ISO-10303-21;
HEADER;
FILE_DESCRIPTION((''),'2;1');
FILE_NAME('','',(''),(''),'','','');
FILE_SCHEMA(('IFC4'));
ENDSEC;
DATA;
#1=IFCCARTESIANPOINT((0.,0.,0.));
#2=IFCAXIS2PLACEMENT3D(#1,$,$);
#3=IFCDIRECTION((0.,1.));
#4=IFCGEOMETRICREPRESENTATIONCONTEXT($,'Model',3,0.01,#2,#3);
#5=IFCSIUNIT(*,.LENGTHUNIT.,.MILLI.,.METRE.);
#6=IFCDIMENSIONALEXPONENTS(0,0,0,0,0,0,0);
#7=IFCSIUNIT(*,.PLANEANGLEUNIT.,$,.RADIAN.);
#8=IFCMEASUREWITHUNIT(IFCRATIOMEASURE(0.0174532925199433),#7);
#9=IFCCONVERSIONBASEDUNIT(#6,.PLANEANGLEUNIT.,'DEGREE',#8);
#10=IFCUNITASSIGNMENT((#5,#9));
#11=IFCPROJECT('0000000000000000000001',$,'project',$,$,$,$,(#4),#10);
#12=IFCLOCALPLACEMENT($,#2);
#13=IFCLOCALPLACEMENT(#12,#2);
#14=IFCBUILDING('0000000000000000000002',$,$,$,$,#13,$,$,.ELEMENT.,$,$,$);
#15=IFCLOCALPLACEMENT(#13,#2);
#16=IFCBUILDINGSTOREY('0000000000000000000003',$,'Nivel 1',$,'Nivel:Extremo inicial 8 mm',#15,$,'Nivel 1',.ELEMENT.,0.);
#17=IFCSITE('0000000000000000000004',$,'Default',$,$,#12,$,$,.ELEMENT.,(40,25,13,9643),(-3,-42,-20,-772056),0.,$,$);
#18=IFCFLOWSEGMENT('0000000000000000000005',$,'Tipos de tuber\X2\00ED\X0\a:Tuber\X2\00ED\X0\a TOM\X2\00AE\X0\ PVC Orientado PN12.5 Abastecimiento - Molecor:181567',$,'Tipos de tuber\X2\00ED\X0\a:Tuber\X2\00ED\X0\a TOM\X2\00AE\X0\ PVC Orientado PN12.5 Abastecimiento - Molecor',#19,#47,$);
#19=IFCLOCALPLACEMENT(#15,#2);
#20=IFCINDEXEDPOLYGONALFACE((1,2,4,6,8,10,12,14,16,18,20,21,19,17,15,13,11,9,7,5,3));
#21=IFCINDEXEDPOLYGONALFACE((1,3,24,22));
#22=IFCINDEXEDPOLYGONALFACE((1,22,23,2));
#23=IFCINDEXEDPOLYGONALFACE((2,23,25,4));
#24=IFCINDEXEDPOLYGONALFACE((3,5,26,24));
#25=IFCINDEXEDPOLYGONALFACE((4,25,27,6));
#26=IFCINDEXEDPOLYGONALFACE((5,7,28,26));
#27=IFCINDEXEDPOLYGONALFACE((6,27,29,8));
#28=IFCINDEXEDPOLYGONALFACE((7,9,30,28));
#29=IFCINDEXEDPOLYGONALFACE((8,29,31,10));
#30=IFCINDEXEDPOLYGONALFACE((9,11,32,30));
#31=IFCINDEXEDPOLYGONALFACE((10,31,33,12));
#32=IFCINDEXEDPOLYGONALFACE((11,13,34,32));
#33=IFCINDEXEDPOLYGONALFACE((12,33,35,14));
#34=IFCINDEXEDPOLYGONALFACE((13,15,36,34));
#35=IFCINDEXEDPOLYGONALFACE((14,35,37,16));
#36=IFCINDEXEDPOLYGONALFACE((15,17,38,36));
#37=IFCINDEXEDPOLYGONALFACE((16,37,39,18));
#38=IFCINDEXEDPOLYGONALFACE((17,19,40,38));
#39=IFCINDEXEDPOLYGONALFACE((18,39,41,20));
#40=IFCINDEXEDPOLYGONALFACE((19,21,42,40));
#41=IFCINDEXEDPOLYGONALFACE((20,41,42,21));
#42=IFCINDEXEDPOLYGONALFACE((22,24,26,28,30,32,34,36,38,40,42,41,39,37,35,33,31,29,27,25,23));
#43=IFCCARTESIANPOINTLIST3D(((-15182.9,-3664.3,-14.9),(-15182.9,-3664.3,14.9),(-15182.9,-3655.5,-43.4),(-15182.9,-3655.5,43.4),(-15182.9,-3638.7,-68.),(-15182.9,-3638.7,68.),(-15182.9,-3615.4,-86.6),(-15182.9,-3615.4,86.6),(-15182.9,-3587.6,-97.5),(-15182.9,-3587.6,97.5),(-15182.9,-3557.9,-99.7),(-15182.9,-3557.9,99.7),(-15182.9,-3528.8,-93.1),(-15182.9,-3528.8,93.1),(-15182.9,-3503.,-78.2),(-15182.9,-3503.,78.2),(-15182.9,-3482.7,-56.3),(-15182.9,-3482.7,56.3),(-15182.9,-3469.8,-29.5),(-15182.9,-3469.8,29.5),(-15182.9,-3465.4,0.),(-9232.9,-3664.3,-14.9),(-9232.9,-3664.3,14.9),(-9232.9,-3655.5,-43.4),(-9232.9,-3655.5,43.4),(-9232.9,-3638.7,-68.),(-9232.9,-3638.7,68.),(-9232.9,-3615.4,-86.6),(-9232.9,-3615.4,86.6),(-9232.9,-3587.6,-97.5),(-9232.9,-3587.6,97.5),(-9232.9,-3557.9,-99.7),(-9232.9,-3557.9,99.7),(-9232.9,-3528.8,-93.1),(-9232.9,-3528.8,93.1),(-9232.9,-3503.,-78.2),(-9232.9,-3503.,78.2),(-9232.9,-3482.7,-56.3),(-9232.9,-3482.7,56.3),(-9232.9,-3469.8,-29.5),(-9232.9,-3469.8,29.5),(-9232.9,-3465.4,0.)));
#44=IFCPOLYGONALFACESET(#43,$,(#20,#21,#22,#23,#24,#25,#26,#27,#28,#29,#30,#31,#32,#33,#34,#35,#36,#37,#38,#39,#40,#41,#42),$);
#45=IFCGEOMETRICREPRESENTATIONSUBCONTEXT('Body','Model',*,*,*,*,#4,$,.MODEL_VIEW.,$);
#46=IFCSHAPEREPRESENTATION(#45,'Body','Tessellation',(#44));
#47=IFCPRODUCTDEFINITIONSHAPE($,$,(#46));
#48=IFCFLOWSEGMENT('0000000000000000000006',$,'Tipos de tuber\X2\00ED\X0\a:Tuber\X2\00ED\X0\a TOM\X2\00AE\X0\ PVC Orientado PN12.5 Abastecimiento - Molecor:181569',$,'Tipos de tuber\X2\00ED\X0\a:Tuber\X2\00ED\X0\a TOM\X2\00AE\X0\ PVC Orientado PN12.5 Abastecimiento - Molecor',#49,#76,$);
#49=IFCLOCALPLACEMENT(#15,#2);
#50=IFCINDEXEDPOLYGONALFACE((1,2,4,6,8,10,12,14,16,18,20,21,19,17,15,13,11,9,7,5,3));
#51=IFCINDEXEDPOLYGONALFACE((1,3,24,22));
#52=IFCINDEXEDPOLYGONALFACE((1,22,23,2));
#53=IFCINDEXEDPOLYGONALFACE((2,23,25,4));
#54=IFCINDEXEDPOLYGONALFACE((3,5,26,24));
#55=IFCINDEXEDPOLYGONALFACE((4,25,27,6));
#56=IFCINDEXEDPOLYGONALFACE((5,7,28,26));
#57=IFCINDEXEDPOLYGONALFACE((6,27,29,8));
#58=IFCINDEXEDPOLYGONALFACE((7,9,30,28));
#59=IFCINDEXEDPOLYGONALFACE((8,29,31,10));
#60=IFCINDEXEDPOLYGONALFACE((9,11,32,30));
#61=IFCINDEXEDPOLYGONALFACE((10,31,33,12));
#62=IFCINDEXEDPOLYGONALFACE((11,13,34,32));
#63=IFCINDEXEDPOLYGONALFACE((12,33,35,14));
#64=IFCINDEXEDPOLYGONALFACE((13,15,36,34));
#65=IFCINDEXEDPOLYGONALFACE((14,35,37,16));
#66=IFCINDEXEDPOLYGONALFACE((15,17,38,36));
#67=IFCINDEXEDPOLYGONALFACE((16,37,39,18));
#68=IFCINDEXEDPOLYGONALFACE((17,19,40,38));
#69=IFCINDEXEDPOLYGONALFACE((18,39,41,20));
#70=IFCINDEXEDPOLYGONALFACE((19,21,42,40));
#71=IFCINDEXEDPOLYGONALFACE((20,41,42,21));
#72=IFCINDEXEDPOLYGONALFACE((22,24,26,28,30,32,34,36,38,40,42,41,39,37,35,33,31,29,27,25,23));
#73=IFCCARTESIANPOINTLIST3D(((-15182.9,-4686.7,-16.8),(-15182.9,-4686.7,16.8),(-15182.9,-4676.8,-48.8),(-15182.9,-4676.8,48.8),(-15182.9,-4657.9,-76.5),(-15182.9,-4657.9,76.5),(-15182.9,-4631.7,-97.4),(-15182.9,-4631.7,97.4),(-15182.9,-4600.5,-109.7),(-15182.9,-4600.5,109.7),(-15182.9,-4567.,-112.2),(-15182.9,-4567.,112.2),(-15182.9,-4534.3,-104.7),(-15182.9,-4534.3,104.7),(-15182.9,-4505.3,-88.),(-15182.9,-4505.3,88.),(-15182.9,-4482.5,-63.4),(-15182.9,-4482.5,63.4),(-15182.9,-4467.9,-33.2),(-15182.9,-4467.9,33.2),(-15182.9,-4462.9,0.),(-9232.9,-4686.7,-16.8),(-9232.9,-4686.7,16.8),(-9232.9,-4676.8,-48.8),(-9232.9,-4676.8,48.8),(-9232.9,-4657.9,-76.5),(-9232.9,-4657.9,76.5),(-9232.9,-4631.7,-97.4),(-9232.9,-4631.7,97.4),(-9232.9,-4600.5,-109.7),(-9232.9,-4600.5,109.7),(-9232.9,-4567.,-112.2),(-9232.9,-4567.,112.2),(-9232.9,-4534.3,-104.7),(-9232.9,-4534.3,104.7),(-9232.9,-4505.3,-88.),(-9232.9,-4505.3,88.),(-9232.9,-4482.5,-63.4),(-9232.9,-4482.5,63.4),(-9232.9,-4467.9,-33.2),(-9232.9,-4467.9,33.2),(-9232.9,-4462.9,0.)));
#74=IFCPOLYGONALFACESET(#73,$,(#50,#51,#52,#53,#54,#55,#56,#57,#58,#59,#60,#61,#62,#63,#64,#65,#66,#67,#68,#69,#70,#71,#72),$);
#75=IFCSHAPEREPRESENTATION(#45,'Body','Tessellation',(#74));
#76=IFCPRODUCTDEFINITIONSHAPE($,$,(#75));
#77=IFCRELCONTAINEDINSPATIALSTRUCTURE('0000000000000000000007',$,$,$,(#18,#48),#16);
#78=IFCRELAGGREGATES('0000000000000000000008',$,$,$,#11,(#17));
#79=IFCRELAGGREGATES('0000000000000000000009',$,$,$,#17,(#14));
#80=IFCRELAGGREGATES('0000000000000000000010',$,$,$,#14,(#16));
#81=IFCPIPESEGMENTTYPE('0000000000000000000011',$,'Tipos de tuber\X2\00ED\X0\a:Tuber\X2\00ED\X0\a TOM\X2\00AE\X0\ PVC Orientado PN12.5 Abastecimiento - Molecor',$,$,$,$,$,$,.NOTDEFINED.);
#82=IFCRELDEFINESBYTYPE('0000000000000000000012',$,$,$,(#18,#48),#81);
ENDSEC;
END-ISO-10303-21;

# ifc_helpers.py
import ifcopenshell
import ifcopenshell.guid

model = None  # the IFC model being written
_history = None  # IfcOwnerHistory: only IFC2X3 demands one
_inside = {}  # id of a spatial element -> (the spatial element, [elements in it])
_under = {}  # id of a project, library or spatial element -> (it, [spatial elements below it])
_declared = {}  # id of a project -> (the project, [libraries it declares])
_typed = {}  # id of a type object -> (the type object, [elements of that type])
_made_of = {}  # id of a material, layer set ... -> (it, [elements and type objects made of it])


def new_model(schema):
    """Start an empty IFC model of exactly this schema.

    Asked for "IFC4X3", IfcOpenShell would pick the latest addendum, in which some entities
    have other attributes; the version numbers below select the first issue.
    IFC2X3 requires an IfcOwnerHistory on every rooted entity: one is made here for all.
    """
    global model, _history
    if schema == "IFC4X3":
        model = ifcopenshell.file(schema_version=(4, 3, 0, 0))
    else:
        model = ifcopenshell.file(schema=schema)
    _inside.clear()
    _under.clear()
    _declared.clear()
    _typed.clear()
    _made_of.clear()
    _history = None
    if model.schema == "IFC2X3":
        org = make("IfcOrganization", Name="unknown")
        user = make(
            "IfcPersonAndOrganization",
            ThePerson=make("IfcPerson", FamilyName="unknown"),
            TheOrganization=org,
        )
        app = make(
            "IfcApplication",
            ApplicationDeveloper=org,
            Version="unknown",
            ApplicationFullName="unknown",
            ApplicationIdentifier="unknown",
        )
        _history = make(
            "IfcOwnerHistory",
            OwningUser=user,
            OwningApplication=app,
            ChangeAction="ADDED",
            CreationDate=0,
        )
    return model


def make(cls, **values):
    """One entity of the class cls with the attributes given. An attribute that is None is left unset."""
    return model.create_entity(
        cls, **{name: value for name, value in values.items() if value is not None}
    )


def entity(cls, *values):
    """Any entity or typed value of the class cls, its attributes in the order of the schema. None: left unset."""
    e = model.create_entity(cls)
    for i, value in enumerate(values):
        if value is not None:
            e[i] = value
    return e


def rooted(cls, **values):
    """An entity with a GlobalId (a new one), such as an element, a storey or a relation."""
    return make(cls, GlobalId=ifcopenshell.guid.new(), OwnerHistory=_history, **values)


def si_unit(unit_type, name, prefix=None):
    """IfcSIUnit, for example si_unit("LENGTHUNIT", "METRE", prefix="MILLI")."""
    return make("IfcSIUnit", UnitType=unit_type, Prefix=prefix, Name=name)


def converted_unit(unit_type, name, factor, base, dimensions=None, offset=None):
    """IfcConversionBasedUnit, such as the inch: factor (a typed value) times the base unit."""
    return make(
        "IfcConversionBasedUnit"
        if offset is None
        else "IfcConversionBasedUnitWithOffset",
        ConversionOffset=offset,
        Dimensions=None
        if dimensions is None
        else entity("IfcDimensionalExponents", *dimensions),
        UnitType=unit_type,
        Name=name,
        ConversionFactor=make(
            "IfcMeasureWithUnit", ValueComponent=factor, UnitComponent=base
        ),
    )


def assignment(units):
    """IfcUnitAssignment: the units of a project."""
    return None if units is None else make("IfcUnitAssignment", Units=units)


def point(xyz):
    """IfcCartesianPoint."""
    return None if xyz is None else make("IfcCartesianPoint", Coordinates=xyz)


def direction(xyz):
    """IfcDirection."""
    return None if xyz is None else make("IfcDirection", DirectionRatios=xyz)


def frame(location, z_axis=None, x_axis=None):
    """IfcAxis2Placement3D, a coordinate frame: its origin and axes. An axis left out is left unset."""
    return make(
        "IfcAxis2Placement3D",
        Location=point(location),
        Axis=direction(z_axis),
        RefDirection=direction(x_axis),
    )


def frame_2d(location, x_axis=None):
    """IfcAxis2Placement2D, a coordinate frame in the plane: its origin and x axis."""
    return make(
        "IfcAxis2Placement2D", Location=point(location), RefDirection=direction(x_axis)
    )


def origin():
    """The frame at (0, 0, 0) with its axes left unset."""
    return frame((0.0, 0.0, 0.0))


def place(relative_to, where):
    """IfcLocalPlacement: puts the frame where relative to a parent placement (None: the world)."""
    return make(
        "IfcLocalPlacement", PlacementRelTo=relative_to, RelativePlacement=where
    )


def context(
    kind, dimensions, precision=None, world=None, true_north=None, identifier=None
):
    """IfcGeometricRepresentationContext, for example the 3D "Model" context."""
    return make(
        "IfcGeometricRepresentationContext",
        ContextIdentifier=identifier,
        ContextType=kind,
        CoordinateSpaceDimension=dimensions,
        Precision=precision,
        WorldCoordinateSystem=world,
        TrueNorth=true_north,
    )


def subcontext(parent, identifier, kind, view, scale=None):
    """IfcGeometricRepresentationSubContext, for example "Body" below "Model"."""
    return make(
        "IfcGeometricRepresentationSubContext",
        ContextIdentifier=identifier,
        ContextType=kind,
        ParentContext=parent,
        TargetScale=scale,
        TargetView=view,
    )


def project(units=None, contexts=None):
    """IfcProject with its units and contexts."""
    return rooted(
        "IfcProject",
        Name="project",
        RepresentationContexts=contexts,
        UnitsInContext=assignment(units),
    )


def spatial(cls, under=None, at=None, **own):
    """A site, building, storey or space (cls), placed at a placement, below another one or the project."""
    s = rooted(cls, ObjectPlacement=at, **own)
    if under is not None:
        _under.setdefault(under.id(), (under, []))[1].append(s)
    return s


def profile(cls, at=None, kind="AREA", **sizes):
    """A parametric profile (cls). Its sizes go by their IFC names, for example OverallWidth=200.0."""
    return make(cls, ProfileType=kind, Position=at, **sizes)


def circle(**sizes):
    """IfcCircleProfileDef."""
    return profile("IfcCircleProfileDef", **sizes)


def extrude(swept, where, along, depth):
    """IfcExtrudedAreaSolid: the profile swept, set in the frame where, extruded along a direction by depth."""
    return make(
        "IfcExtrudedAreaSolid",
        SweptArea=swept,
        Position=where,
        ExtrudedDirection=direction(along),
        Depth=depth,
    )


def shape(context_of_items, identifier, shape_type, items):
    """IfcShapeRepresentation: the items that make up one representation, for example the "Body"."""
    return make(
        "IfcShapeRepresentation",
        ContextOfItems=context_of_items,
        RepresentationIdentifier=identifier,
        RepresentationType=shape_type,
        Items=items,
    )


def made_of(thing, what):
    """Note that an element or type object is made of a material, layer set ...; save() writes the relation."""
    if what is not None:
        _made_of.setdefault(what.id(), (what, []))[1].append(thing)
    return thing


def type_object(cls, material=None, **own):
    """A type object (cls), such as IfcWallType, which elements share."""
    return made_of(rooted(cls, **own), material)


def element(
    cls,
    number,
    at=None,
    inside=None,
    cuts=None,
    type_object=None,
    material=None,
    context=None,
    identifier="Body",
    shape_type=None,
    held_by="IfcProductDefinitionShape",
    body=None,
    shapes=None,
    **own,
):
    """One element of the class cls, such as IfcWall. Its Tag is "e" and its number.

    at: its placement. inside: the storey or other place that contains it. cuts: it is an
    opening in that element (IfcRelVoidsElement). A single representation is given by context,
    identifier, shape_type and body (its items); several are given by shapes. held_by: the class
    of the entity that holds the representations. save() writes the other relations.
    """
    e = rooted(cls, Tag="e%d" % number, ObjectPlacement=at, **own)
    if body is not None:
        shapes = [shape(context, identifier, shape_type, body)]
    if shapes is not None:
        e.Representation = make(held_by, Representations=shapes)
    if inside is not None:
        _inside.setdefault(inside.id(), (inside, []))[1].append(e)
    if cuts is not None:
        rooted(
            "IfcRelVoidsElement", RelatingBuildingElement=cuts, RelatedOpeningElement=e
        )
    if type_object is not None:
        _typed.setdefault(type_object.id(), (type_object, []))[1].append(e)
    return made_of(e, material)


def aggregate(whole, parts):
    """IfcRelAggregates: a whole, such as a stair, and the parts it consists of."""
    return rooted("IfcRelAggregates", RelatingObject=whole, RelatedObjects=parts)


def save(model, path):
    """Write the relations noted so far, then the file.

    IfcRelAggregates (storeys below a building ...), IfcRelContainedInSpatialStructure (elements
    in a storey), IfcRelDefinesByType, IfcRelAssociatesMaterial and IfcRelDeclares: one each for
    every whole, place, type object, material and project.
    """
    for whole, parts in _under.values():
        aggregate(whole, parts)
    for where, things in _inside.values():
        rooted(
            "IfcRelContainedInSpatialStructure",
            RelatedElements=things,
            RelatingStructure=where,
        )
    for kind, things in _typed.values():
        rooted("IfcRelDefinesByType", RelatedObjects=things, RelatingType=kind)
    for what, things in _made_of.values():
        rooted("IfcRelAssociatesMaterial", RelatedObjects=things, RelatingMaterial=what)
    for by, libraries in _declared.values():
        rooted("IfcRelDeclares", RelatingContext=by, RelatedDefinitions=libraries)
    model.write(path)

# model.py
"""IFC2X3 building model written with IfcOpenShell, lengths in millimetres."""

from ifc_helpers import new_model, entity, si_unit, converted_unit, direction, frame, frame_2d, origin, place, context, subcontext, project, spatial, circle, extrude, type_object, element, save


model = new_model("IFC2X3")

# Units and contexts
model_context = context("Model", 3, precision=0.01, world=origin(), true_north=direction((0.0, 1.0)))
body_context = subcontext(model_context, "Body", "Model", "MODEL_VIEW")
ifc_project = project(units=[si_unit("LENGTHUNIT", "METRE", prefix="MILLI"), converted_unit("PLANEANGLEUNIT", "DEGREE", entity("IfcRatioMeasure", 0.0174532925199433), si_unit("PLANEANGLEUNIT", "RADIAN"), dimensions=[0, 0, 0, 0, 0, 0, 0])], contexts=[model_context])

# Site, building, storey
site_placement = place(None, origin())
site = spatial("IfcSite", under=ifc_project, at=site_placement, Name="Default", CompositionType="ELEMENT", RefLatitude=(40, 25, 13, 9643), RefLongitude=(-3, -42, -20, -772056), RefElevation=0.0)
building_placement = place(site_placement, origin())
building = spatial("IfcBuilding", under=site, at=building_placement, CompositionType="ELEMENT")
storey_placement = place(building_placement, origin())
storey = spatial("IfcBuildingStorey", under=building, at=storey_placement, Name="Nivel 1", ObjectType="Nivel:Extremo inicial 8 mm", LongName="Nivel 1", CompositionType="ELEMENT", Elevation=0.0)

# Flow segments
pipe_segment_type = type_object("IfcPipeSegmentType", Name="Tipos de tubería:Tubería TOM® PVC Orientado PN12.5 Abastecimiento - Molecor", PredefinedType="NOTDEFINED")
flow_segment_1_placement = place(storey_placement, frame((-15182.9, -3667.0, -101.6)))
element("IfcFlowSegment", 1, at=flow_segment_1_placement, inside=storey, type_object=pipe_segment_type, Name="Tipos de tubería:Tubería TOM® PVC Orientado PN12.5 Abastecimiento - Molecor:181567", ObjectType="Tipos de tubería:Tubería TOM® PVC Orientado PN12.5 Abastecimiento - Molecor", context=body_context, shape_type="SweptSolid", body=[
    extrude(circle(Radius=100.0, at=frame_2d((0.0, 0.0), x_axis=(1.0, 0.0))), frame((0.0, 101.6, 101.6), z_axis=(1.0, 0.0, 0.0), x_axis=(0.0, 1.0, 0.0)), (0.0, 0.0, 1.0), 5950.0),
])
flow_segment_2_placement = place(storey_placement, frame((-15182.9, -4689.5, -114.1)))
element("IfcFlowSegment", 2, at=flow_segment_2_placement, inside=storey, type_object=pipe_segment_type, Name="Tipos de tubería:Tubería TOM® PVC Orientado PN12.5 Abastecimiento - Molecor:181569", ObjectType="Tipos de tubería:Tubería TOM® PVC Orientado PN12.5 Abastecimiento - Molecor", context=body_context, shape_type="SweptSolid", body=[
    extrude(circle(Radius=112.5, at=frame_2d((0.0, 0.0), x_axis=(1.0, 0.0))), frame((0.0, 114.1, 114.1), z_axis=(1.0, 0.0, 0.0), x_axis=(0.0, 1.0, 0.0)), (0.0, 0.0, 1.0), 5950.0),
])

save(model, "model.ifc")
